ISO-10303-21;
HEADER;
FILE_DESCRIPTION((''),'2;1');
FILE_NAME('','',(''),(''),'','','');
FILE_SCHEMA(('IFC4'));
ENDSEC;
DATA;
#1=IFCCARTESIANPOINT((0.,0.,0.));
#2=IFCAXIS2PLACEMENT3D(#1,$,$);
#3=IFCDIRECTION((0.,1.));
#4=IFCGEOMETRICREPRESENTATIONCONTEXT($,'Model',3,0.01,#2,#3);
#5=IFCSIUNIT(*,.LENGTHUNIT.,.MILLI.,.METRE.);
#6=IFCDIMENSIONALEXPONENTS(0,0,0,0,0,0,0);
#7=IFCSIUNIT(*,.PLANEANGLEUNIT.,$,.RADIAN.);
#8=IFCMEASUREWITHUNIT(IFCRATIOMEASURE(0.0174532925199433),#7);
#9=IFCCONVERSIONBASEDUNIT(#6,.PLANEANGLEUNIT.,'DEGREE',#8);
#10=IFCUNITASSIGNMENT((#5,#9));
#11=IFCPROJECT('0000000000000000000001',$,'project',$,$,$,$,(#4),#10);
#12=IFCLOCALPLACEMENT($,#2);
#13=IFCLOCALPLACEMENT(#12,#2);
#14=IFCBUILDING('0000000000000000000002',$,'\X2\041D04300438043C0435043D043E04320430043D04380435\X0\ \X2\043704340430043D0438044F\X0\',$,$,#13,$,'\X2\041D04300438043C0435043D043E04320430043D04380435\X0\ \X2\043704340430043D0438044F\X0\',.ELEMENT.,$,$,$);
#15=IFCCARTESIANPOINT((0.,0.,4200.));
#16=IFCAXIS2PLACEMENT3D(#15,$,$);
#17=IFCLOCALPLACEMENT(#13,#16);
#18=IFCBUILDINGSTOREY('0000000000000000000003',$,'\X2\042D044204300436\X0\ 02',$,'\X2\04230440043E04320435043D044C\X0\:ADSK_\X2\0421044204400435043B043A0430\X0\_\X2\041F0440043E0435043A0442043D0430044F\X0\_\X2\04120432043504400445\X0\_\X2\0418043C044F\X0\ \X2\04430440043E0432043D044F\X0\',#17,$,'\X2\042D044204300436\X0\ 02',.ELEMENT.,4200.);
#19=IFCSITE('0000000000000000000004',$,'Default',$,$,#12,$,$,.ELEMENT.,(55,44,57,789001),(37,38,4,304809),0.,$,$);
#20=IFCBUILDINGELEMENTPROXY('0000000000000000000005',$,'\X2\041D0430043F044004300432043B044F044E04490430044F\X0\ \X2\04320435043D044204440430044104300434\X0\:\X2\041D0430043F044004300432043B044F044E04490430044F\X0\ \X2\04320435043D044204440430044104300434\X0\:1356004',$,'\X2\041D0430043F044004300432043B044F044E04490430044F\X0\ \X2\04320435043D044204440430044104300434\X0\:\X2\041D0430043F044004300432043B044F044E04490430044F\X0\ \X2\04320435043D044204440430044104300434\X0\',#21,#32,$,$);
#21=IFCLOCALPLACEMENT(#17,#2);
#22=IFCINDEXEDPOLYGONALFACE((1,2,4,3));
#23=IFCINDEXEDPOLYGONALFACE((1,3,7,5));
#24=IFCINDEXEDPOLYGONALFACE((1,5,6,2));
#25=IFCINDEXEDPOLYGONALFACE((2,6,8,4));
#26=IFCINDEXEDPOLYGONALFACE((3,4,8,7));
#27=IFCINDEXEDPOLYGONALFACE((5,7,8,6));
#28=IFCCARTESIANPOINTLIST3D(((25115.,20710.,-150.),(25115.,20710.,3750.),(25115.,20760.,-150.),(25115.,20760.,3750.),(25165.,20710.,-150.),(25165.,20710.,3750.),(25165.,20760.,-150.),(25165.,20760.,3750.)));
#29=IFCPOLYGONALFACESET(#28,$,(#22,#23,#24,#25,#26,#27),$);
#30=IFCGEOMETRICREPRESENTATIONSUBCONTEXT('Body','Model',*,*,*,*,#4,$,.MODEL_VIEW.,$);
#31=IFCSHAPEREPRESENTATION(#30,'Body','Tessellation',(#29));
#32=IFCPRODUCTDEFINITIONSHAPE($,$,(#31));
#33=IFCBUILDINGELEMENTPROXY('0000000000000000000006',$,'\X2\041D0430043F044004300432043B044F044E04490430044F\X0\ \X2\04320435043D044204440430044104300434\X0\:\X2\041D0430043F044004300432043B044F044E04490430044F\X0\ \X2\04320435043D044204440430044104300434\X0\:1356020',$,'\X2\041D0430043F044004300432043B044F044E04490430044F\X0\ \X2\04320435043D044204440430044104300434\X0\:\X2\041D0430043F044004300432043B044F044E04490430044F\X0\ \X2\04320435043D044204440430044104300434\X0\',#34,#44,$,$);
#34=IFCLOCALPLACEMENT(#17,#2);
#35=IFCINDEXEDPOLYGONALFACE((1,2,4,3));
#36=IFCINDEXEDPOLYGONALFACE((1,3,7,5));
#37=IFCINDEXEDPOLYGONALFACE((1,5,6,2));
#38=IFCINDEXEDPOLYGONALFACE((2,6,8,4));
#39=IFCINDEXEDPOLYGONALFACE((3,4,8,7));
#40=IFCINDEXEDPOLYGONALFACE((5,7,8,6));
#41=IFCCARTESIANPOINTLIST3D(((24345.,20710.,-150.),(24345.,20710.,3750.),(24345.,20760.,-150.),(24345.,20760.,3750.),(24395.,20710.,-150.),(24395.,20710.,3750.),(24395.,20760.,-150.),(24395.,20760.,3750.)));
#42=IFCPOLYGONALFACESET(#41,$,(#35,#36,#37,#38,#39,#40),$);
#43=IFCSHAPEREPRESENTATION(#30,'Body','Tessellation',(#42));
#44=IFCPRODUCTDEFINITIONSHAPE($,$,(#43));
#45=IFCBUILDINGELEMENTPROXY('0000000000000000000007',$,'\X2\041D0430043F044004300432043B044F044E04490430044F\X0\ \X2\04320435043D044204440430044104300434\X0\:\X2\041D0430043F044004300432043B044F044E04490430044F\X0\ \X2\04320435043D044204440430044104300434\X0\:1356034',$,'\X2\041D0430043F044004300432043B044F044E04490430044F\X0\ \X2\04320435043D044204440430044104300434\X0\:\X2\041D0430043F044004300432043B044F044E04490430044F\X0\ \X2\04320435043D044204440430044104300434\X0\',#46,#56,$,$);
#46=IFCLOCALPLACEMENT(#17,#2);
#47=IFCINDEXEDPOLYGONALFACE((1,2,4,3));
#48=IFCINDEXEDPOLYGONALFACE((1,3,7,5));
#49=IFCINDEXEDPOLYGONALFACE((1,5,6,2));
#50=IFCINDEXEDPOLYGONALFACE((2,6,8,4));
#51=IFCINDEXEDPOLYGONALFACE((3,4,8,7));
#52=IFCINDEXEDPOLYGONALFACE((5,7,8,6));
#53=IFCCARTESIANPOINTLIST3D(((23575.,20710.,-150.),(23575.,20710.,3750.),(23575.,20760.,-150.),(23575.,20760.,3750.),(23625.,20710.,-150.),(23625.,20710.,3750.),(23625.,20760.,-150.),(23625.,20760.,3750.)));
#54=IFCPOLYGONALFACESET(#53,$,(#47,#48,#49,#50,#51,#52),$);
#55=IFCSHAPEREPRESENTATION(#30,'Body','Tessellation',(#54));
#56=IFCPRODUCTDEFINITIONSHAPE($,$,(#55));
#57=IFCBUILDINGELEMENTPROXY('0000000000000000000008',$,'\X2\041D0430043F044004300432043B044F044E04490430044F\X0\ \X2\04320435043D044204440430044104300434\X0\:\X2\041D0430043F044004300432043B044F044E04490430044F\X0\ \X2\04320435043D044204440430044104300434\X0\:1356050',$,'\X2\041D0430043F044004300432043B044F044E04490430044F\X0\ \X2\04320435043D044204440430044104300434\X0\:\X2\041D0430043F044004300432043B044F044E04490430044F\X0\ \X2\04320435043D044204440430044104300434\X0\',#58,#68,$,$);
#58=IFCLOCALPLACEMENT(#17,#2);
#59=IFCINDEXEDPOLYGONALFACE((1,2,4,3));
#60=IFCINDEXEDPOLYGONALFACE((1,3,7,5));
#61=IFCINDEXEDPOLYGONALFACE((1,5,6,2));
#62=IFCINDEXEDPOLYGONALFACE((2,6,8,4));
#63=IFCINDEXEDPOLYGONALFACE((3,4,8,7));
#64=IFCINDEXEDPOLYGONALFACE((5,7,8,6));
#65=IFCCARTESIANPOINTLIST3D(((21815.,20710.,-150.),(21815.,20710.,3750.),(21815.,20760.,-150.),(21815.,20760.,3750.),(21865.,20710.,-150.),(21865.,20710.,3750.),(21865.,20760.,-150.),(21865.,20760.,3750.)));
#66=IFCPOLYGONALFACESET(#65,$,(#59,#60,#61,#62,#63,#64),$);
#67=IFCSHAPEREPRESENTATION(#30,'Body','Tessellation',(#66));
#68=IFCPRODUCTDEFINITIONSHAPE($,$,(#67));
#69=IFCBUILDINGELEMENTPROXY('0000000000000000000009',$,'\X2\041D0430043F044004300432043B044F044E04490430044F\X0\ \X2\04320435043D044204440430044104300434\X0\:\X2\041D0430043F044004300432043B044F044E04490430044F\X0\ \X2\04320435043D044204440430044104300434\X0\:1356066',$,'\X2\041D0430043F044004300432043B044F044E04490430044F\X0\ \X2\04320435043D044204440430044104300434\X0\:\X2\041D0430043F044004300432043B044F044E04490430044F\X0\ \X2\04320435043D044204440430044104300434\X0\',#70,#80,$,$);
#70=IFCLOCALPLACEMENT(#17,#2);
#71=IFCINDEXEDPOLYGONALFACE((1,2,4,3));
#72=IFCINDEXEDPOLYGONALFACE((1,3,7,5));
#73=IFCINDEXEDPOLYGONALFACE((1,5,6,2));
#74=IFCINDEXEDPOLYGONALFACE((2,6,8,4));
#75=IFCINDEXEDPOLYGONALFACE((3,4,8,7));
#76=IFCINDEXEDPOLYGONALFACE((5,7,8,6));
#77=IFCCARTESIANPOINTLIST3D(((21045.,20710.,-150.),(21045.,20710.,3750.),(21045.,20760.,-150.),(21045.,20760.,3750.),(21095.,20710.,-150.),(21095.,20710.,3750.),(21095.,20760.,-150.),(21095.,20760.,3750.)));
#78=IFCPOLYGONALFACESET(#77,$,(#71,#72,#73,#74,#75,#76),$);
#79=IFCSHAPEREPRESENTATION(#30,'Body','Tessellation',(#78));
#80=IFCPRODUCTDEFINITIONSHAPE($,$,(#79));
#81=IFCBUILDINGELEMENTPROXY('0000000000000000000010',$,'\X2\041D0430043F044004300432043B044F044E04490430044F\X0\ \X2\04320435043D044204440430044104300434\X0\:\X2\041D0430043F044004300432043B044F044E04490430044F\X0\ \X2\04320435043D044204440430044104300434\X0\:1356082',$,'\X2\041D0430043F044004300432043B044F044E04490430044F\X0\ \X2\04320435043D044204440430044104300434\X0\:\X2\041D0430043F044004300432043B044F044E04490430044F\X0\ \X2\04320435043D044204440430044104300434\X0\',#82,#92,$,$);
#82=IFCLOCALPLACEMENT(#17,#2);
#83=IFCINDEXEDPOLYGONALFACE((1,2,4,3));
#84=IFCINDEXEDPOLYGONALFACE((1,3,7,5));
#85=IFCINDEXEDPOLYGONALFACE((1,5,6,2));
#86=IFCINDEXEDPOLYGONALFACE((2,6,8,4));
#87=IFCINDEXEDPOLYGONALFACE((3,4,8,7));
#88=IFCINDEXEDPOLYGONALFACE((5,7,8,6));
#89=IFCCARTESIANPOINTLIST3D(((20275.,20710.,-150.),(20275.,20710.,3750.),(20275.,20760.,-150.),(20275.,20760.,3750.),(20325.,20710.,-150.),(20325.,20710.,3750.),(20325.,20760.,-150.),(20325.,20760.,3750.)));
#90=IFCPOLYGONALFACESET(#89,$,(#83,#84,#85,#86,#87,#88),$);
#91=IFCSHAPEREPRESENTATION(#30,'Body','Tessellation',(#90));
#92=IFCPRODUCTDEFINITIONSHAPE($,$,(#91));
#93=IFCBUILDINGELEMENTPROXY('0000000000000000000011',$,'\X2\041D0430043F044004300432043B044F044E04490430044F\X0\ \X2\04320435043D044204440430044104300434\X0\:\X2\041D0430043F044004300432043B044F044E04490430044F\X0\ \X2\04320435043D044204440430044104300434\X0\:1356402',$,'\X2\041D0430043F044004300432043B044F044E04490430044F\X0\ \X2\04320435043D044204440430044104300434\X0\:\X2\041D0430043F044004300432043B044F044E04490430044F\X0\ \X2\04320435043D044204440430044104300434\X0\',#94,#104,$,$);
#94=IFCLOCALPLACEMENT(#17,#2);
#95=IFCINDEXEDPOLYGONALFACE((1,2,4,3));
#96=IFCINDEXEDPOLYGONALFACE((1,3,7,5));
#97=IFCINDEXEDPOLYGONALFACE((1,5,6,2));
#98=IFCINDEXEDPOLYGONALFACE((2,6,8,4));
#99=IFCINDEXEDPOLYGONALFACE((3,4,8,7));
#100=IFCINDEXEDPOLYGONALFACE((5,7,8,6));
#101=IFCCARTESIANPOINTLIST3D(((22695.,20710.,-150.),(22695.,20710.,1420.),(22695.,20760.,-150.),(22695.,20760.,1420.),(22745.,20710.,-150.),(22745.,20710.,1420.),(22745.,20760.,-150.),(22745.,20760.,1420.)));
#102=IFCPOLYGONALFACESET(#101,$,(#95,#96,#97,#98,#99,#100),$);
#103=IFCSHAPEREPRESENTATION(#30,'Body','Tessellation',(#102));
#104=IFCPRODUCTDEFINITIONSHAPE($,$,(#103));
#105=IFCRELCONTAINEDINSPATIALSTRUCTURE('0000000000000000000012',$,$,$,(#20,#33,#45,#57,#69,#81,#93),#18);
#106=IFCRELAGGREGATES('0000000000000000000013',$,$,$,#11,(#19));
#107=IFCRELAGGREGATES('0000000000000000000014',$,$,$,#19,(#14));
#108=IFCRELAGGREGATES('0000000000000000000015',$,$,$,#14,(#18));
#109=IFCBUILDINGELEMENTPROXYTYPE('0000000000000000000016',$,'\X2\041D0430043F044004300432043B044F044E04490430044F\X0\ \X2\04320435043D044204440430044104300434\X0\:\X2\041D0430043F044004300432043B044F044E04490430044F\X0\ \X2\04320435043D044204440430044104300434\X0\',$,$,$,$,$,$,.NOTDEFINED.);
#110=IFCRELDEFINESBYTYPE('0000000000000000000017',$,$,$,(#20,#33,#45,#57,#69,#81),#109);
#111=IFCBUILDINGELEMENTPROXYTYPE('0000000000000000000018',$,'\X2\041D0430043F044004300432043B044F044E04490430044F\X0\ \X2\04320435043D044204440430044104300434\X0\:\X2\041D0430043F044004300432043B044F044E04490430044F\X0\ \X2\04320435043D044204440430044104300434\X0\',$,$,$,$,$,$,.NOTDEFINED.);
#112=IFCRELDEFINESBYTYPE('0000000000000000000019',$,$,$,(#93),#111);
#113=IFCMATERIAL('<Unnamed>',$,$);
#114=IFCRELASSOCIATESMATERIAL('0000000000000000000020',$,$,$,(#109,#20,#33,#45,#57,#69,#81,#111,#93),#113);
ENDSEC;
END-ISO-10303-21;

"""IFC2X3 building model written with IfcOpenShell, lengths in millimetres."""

from ifc_helpers import new_model, entity, si_unit, converted_unit, direction, frame, origin, origin_2d_with_axis, place, context, subcontext, project, spatial, rectangle, extrude, source, transform, mapped, material, type_object, type_shapes, element, save


model = new_model("IFC2X3")

# Units and contexts
model_context = context("Model", 3, precision=0.01, world=origin(), true_north=direction((0.0, 1.0)))
body_context = subcontext(model_context, "Body", "Model", "MODEL_VIEW")
ifc_project = project(units=[si_unit("LENGTHUNIT", "METRE", prefix="MILLI"), converted_unit("PLANEANGLEUNIT", "DEGREE", entity("IfcRatioMeasure", 0.0174532925199433), si_unit("PLANEANGLEUNIT", "RADIAN"), dimensions=[0, 0, 0, 0, 0, 0, 0])], contexts=[model_context])

# Site, building, storey
site_placement = place(None, origin())
site = spatial("IfcSite", under=ifc_project, at=site_placement, Name="Default", CompositionType="ELEMENT", RefLatitude=(55, 44, 57, 789001), RefLongitude=(37, 38, 4, 304809), RefElevation=0.0)
building_placement = place(site_placement, origin())
building = spatial("IfcBuilding", under=site, at=building_placement, Name="Наименование здания", LongName="Наименование здания", CompositionType="ELEMENT")
storey_placement = place(building_placement, frame((0.0, 0.0, 4200.0)))
storey = spatial("IfcBuildingStorey", under=building, at=storey_placement, Name="Этаж 02", ObjectType="Уровень:ADSK_Стрелка_Проектная_Вверх_Имя уровня", LongName="Этаж 02", CompositionType="ELEMENT", Elevation=4200.0)

# Building element proxies
ifc_material_1 = material(Name="<Unnamed>")
building_element_proxy_type_1 = type_object("IfcBuildingElementProxyType", Name="Направляющая вентфасад:Направляющая вентфасад", PredefinedType="NOTDEFINED", material=ifc_material_1)
shared_shape_1 = source(origin(), body_context, "Body", "SweptSolid", [
    extrude(rectangle(XDim=50.0, YDim=50.0, at=origin_2d_with_axis()), frame((25.0, -25.0, 0.0), z_axis=(0.0, 0.0, 1.0), x_axis=(-1.0, 0.0, 0.0)), (0.0, 0.0, 1.0), 3900.0),
])
type_shapes(building_element_proxy_type_1, [shared_shape_1])
for number, where, z_axis, x_axis, name in (
    (1, (25165.0, 20710.0, -150.0), (0.0, 0.0, 1.0), (-1.0, 0.0, 0.0), "Направляющая вентфасад:Направляющая вентфасад:1356004"),
    (2, (24395.0, 20710.0, -150.0), (0.0, 0.0, 1.0), (-1.0, 0.0, 0.0), "Направляющая вентфасад:Направляющая вентфасад:1356020"),
    (3, (23625.0, 20710.0, -150.0), (0.0, 0.0, 1.0), (-1.0, 0.0, 0.0), "Направляющая вентфасад:Направляющая вентфасад:1356034"),
    (4, (21865.0, 20710.0, -150.0), (0.0, 0.0, 1.0), (-1.0, 0.0, 0.0), "Направляющая вентфасад:Направляющая вентфасад:1356050"),
    (5, (21095.0, 20710.0, -150.0), (0.0, 0.0, 1.0), (-1.0, 0.0, 0.0), "Направляющая вентфасад:Направляющая вентфасад:1356066"),
    (6, (20325.0, 20710.0, -150.0), (0.0, 0.0, 1.0), (-1.0, 0.0, 0.0), "Направляющая вентфасад:Направляющая вентфасад:1356082"),
):
    element("IfcBuildingElementProxy", number, at=place(storey_placement, frame(where, z_axis=z_axis, x_axis=x_axis)), inside=storey, type_object=building_element_proxy_type_1, material=ifc_material_1, Name=name, ObjectType="Направляющая вентфасад:Направляющая вентфасад", context=body_context, shape_type="MappedRepresentation", body=[
        mapped(shared_shape_1, transform((0.0, 0.0, 0.0), scale=1.0)),
    ])
building_element_proxy_type_2 = type_object("IfcBuildingElementProxyType", Name="Направляющая вентфасад:Направляющая вентфасад", PredefinedType="NOTDEFINED", material=ifc_material_1)
shared_shape_2 = source(origin(), body_context, "Body", "SweptSolid", [
    extrude(rectangle(XDim=50.0, YDim=50.0, at=origin_2d_with_axis()), frame((25.0, -25.0, 0.0), z_axis=(0.0, 0.0, 1.0), x_axis=(-1.0, 0.0, 0.0)), (0.0, 0.0, 1.0), 1570.0),
])
type_shapes(building_element_proxy_type_2, [shared_shape_2])
proxy_1_placement = place(storey_placement, frame((22745.0, 20710.0, -150.0), z_axis=(0.0, 0.0, 1.0), x_axis=(-1.0, 0.0, 0.0)))
element("IfcBuildingElementProxy", 7, at=proxy_1_placement, inside=storey, type_object=building_element_proxy_type_2, material=ifc_material_1, Name="Направляющая вентфасад:Направляющая вентфасад:1356402", ObjectType="Направляющая вентфасад:Направляющая вентфасад", context=body_context, shape_type="MappedRepresentation", body=[
    mapped(shared_shape_2, transform((0.0, 0.0, 0.0), scale=1.0)),
])

save(model, "model.ifc")
